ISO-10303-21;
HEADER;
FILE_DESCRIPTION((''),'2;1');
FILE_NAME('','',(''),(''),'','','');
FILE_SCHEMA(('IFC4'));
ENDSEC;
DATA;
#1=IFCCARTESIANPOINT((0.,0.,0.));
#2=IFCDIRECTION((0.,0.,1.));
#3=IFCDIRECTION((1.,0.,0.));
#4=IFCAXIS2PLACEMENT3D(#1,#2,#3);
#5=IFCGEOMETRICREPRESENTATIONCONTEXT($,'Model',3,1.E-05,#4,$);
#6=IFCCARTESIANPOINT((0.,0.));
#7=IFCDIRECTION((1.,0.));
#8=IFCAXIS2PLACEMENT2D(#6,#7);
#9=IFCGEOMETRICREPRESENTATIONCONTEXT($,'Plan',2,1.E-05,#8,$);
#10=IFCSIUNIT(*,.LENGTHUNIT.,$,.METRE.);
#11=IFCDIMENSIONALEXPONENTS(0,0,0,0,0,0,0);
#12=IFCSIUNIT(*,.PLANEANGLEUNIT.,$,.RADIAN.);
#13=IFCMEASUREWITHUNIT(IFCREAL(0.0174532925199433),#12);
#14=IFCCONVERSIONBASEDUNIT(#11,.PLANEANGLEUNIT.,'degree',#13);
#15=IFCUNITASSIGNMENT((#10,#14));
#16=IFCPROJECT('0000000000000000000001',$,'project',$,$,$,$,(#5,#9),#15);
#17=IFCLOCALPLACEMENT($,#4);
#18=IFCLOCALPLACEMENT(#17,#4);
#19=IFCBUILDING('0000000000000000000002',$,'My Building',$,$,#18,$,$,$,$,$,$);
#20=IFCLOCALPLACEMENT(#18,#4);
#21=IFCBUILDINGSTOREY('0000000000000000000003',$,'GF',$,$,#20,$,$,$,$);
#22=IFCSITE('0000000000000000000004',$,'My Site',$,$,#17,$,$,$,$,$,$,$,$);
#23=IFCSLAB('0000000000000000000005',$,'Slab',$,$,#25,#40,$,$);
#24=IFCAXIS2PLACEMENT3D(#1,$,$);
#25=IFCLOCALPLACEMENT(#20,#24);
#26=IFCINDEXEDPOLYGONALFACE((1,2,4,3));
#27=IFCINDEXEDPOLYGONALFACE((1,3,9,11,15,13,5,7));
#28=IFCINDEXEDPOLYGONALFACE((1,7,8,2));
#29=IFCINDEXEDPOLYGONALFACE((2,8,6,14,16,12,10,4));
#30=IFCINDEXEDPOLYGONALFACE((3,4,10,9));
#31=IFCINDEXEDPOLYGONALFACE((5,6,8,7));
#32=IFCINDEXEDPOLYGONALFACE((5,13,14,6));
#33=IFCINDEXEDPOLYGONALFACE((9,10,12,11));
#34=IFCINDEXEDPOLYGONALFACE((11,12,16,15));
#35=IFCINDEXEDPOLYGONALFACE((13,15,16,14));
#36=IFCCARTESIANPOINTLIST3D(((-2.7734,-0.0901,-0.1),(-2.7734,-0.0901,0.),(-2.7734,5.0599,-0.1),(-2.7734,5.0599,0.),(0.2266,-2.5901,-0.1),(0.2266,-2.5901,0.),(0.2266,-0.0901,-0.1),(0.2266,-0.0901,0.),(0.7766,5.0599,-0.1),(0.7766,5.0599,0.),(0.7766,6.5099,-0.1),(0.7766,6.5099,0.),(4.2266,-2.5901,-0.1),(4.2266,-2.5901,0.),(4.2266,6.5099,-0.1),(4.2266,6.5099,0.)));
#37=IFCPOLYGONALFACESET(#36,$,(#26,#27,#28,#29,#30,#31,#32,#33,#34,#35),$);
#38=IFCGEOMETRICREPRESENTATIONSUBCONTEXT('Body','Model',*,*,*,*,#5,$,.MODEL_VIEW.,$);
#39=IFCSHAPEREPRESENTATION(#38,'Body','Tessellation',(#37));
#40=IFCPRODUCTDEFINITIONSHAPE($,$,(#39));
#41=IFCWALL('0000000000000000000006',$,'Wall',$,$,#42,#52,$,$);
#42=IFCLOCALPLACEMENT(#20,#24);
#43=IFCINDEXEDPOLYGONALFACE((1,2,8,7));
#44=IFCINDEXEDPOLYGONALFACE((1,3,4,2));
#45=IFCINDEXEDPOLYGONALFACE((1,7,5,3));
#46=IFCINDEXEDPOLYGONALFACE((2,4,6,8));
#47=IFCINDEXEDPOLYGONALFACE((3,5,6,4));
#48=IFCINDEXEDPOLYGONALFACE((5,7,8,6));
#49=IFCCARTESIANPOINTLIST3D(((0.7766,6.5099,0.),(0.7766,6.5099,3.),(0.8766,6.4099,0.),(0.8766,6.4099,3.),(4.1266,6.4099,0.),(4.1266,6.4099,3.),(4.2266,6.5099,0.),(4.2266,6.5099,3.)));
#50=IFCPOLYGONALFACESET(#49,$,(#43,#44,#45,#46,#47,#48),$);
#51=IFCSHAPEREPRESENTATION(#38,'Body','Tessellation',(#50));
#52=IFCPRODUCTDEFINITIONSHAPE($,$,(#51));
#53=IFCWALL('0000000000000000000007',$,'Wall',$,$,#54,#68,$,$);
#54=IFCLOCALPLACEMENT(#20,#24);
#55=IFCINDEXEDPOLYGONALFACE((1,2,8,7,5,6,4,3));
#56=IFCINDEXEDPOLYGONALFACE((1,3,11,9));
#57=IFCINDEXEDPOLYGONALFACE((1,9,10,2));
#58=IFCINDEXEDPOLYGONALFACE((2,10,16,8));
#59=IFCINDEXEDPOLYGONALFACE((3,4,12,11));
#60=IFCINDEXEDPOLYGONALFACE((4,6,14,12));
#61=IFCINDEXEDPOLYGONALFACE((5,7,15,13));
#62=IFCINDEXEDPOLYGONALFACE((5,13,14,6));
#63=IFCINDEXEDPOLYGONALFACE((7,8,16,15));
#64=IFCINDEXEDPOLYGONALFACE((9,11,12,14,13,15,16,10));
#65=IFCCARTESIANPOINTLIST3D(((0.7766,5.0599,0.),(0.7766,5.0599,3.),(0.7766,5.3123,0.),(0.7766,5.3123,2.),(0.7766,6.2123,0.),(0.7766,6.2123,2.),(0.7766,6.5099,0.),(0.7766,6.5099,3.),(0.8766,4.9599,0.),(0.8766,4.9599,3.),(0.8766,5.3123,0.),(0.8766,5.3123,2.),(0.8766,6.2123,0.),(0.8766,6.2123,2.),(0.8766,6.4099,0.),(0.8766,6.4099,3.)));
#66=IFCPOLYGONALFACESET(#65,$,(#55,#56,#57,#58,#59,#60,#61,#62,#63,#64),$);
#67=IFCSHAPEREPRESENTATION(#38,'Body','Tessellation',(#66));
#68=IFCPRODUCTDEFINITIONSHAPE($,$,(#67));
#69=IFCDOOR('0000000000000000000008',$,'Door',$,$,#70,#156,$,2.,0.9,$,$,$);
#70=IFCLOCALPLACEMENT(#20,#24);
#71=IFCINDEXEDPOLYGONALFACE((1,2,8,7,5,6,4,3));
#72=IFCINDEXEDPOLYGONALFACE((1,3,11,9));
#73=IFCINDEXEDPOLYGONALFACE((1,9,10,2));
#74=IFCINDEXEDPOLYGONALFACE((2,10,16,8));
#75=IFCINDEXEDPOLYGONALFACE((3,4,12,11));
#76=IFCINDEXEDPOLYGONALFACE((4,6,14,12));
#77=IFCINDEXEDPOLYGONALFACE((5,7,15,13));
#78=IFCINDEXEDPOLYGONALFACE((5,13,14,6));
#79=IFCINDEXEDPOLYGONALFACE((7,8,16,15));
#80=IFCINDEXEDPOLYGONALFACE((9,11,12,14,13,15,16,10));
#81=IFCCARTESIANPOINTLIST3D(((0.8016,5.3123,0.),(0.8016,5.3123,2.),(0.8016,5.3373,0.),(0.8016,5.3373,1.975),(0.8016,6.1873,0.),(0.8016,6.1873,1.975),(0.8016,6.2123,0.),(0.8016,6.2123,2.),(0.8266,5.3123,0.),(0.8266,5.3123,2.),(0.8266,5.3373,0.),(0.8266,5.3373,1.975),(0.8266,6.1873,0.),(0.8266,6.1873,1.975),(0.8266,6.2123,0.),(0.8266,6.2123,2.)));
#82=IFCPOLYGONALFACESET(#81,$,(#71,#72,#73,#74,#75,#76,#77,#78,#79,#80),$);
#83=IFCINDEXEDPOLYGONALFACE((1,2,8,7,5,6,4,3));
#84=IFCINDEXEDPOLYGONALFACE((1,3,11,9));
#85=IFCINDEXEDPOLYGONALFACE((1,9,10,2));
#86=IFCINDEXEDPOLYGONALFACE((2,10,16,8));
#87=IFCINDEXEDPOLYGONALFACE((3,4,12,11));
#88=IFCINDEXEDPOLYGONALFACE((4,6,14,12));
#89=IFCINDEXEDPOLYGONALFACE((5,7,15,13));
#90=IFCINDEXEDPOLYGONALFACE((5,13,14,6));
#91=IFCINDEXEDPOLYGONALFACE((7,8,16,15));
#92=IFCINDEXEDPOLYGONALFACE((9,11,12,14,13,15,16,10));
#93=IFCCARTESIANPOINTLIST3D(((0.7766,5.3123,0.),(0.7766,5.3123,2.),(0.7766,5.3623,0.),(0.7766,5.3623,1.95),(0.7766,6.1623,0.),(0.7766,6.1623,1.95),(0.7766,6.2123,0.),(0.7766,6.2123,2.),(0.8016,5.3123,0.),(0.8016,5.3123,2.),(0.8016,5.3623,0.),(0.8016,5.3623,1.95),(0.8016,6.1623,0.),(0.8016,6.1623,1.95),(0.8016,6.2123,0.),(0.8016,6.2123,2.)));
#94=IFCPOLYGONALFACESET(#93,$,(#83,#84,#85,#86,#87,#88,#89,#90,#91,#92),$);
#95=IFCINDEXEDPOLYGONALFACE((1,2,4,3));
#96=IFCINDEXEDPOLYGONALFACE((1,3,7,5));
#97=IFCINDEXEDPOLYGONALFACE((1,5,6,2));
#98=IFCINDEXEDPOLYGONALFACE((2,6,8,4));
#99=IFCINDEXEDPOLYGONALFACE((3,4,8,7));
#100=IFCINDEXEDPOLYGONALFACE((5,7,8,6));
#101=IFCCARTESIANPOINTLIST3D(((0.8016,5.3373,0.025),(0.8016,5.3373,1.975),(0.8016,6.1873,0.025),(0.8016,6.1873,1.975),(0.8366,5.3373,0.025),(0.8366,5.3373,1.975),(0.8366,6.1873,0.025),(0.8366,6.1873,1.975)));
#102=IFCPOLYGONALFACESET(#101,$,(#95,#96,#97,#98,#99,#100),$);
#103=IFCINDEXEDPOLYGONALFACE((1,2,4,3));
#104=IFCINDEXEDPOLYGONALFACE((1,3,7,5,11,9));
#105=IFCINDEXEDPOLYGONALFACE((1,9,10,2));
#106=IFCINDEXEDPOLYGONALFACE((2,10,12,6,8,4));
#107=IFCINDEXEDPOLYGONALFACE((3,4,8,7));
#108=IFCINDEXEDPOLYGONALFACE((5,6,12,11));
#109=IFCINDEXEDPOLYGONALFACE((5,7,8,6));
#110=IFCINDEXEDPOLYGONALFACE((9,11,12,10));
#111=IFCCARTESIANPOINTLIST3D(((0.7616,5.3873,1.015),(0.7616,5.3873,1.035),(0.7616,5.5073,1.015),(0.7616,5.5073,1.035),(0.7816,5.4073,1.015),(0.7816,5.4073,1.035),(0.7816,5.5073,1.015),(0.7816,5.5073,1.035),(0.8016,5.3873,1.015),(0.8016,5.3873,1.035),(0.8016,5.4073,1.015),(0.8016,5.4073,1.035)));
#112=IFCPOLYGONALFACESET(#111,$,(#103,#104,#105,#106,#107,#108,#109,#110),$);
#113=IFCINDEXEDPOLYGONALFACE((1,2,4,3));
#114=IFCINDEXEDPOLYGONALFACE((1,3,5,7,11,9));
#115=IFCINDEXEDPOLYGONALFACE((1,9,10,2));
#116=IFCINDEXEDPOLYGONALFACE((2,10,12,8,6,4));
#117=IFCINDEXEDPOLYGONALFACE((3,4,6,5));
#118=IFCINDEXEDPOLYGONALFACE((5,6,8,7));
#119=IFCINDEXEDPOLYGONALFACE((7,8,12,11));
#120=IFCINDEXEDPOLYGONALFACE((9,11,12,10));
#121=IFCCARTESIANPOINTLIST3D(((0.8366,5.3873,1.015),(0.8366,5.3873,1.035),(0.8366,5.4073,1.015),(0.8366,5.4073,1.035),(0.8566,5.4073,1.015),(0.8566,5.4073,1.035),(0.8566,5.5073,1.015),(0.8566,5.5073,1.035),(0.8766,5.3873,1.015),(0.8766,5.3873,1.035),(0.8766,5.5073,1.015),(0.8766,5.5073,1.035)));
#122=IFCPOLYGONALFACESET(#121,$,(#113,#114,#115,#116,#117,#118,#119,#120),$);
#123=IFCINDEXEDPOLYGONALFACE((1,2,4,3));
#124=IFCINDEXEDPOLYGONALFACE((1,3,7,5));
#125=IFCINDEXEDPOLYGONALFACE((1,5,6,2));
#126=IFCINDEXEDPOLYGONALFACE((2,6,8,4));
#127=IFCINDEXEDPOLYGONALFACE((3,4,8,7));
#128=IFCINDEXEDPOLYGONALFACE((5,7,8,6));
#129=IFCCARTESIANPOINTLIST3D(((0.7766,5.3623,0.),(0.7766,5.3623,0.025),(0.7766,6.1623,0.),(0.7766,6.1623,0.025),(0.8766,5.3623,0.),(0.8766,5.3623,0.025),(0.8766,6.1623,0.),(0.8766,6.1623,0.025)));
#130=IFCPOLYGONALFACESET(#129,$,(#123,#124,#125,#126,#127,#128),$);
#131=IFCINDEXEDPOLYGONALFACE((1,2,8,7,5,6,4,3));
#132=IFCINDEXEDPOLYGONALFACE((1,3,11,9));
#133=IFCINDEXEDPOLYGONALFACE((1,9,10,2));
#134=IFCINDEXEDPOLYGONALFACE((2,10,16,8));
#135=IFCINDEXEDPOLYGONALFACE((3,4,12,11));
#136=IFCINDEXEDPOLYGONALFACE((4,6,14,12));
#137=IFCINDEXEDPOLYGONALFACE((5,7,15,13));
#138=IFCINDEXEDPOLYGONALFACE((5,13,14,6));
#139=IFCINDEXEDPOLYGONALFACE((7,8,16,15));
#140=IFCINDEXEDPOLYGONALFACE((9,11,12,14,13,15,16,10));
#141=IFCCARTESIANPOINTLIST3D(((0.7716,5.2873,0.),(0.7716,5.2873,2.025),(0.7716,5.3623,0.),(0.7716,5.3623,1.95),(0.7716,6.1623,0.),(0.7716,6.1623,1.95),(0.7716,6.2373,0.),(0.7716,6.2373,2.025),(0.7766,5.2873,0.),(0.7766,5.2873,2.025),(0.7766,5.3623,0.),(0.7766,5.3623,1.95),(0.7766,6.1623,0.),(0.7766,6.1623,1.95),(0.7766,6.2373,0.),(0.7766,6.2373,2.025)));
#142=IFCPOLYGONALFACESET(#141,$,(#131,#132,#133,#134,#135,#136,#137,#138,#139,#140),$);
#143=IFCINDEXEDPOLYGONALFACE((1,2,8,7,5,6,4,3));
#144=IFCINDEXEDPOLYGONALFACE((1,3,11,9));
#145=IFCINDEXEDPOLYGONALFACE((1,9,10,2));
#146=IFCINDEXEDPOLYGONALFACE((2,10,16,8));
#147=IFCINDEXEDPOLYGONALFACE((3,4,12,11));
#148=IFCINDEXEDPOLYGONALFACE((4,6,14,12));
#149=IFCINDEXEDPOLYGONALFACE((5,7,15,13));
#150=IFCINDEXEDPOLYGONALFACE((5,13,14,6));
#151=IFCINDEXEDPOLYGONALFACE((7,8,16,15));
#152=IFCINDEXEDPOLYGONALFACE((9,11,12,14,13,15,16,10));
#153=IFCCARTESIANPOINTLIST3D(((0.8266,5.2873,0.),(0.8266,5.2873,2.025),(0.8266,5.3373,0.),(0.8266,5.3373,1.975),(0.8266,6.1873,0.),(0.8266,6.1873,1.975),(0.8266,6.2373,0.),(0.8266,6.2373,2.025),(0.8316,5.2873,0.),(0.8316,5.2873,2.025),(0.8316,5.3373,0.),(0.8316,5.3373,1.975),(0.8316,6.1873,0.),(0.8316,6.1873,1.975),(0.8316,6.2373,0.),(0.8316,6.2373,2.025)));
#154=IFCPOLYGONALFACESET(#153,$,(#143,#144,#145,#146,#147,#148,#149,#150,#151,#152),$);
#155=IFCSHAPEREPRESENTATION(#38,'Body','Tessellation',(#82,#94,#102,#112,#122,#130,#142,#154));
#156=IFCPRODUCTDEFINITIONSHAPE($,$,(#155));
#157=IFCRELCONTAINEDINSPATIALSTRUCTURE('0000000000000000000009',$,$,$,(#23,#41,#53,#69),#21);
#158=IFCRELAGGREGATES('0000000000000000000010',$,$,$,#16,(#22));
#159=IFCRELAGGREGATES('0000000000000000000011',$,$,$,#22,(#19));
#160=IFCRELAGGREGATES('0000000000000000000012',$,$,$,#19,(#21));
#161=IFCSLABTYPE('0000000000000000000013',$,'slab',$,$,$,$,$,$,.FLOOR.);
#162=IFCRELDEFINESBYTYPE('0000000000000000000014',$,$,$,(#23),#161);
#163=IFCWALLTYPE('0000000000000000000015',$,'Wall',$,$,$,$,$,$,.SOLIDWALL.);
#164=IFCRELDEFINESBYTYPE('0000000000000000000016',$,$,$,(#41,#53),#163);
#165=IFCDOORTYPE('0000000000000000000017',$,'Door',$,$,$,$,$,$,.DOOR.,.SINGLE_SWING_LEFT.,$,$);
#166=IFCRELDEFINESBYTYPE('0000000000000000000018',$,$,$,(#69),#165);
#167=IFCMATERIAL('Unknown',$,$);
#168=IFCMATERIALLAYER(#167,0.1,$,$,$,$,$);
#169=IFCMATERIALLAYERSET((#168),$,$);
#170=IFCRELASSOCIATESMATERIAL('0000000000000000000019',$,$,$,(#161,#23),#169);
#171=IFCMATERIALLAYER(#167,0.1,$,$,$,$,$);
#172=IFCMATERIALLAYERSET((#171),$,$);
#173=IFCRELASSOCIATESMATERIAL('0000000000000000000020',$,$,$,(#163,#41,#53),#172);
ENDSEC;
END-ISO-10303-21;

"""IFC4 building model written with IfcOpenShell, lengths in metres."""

from ifc_helpers import new_model, entity, si_unit, converted_unit, frame, origin_with_axes, origin_2d_with_axis, place, context, subcontext, project, spatial, line, indexed_curve, outline, extrude, shape, source, transform, mapped, material, layer, layer_set, layer_usage, type_object, type_shapes, element, fill, save


model = new_model("IFC4")

# Units and contexts
model_context = context("Model", 3, precision=1e-05, world=origin_with_axes())
plan_context = context("Plan", 2, precision=1e-05, world=origin_2d_with_axis())
body_context_1 = subcontext(model_context, "Body", "Model", "MODEL_VIEW")
body_context_2 = subcontext(plan_context, "Body", "Plan", "PLAN_VIEW")
ifc_project = project(units=[si_unit("LENGTHUNIT", "METRE"), converted_unit("PLANEANGLEUNIT", "degree", entity("IfcReal", 0.0174532925199433), si_unit("PLANEANGLEUNIT", "RADIAN"), dimensions=[0, 0, 0, 0, 0, 0, 0])], contexts=[model_context, plan_context])

# Site, building, storey
site_placement = place(None, origin_with_axes())
site = spatial("IfcSite", under=ifc_project, at=site_placement, Name="My Site")
building_placement = place(site_placement, origin_with_axes())
building = spatial("IfcBuilding", under=site, at=building_placement, Name="My Building")
storey_placement = place(building_placement, origin_with_axes())
storey = spatial("IfcBuildingStorey", under=building, at=storey_placement, Name="GF")

# Slab
ifc_material = material(Name="Unknown")
ifc_layer_1 = layer(ifc_material, 0.1)
ifc_layer_set_1 = layer_set([ifc_layer_1])
ifc_layer_usage_1 = layer_usage(ifc_layer_set_1, "AXIS3", "POSITIVE", -0.1)
slab_type = type_object("IfcSlabType", Name="slab", PredefinedType="FLOOR", material=ifc_layer_set_1)
slab_placement = place(storey_placement, frame((4.2266, -2.5901, 0.0), z_axis=(0.0, 0.0, 1.0), x_axis=(1.0, 0.0, 0.0)))
element("IfcSlab", 1, at=slab_placement, inside=storey, type_object=slab_type, material=ifc_layer_usage_1, Name="Slab", context=body_context_1, shape_type="SweptSolid", body=[
    extrude(outline(indexed_curve([(0.0, 0.0), (0.0, 9.1), (-3.45, 9.1), (-3.45, 7.65), (-7.0, 7.65), (-7.0, 2.5), (-4.0, 2.5), (-4.0, 0.0), (0.0, 0.0)])), frame((0.0, 0.0, -0.1), z_axis=(0.0, 0.0, 1.0), x_axis=(1.0, 0.0, 0.0)), (0.0, 0.0, 1.0), 0.1),
])

# Wall
ifc_layer_2 = layer(ifc_material, 0.1)
ifc_layer_set_2 = layer_set([ifc_layer_2])
ifc_layer_usage_2 = layer_usage(ifc_layer_set_2, "AXIS2", "POSITIVE", 0.0)
wall_type = type_object("IfcWallType", Name="Wall", PredefinedType="SOLIDWALL", material=ifc_layer_set_2)
wall_1_placement = place(storey_placement, frame((4.2266, 6.5099, 0.0), z_axis=(0.0, 0.0, 1.0), x_axis=(-1.0, 0.0, 0.0)))
element("IfcWall", 2, at=wall_1_placement, inside=storey, type_object=wall_type, material=ifc_layer_usage_2, Name="Wall", context=body_context_1, shape_type="SweptSolid", body=[
    extrude(outline(indexed_curve([(0.0, 0.0), (0.1, 0.1), (3.35, 0.1), (3.45, 0.0)], segments=[line(1, 2, 3, 4, 1)])), origin_with_axes(), (0.0, 0.0, 1.0), 3.0),
])

# Wall, opening, door
ifc_layer_usage_3 = layer_usage(ifc_layer_set_2, "AXIS2", "POSITIVE", 0.0)
wall_2_placement = place(storey_placement, frame((0.7766, 6.5099, 0.0), z_axis=(0.0, 0.0, 1.0), x_axis=(0.0, -1.0, 0.0)))
wall_2 = element("IfcWall", 3, at=wall_2_placement, inside=storey, type_object=wall_type, material=ifc_layer_usage_3, Name="Wall", context=body_context_1, shape_type="SweptSolid", body=[
    extrude(outline(indexed_curve([(0.0, 0.0), (0.1, 0.1), (1.55, 0.1), (1.45, 0.0)], segments=[line(1, 2, 3, 4, 1)])), origin_with_axes(), (0.0, 0.0, 1.0), 3.0),
])
shared_shape_1 = source(origin_with_axes(), body_context_1, "Body", "SweptSolid", [
    extrude(outline(indexed_curve([(0.0, 0.0), (0.9, 0.0), (0.9, 2.0), (0.0, 2.0)], segments=[line(1, 2, 3, 4, 1)])), frame((0.0, -0.6, 0.0), z_axis=(0.0, -1.0, 0.0), x_axis=(1.0, 0.0, 0.0)), (0.0, 0.0, -1.0), 1.2),
])
opening_1_placement = place(wall_2_placement, frame((0.2976, 0.0, 0.0), z_axis=(0.0, 0.0, 1.0), x_axis=(1.0, 0.0, 0.0)))
opening_1 = element("IfcOpeningElement", 4, at=opening_1_placement, cuts=wall_2, PredefinedType="OPENING", context=body_context_1, shape_type="MappedRepresentation", body=[
    mapped(shared_shape_1, transform((0.0, 0.0, 0.0), x_axis=(1.0, 0.0, 0.0), y_axis=(0.0, 1.0, 0.0), z_axis=(0.0, 0.0, 1.0), scale=1.0)),
])
door_type = type_object("IfcDoorType", Name="Door", OperationType="SINGLE_SWING_LEFT", PredefinedType="DOOR")
shared_shape_2 = source(origin_with_axes(), body_context_1, "Body", "SweptSolid", [
    extrude(outline(indexed_curve([(0.0, 0.0), (0.0, 2.0), (0.9, 2.0), (0.9, 0.0), (0.875, 0.0), (0.875, 1.975), (0.025, 1.975), (0.025, 0.0)], segments=[line(1, 2, 3, 4, 5, 6, 7, 8, 1)])), frame((0.0, 0.025, 0.0), z_axis=(0.0, -1.0, 0.0), x_axis=(1.0, 0.0, 0.0)), (0.0, 0.0, -1.0), 0.025),
    extrude(outline(indexed_curve([(0.0, 0.0), (0.0, 2.0), (0.9, 2.0), (0.9, 0.0), (0.85, 0.0), (0.85, 1.95), (0.05, 1.95), (0.05, 0.0)], segments=[line(1, 2, 3, 4, 5, 6, 7, 8, 1)])), frame((0.0, 0.0, 0.0), z_axis=(0.0, -1.0, 0.0), x_axis=(1.0, 0.0, 0.0)), (0.0, 0.0, -1.0), 0.025),
    extrude(outline(indexed_curve([(0.0, 0.0), (0.85, 0.0), (0.85, 0.035), (0.0, 0.035)], segments=[line(1, 2, 3, 4, 1)])), frame((0.025, 0.025, 0.025), z_axis=(0.0, 0.0, 1.0), x_axis=(1.0, 0.0, 0.0)), (0.0, 0.0, 1.0), 1.95),
    extrude(outline(indexed_curve([(0.0, 0.0), (0.0, -0.04), (-0.12, -0.04), (-0.12, -0.02), (-0.02, -0.02), (-0.02, 0.0)], segments=[line(1, 2, 3, 4, 5, 6, 1)])), frame((0.825, 0.025, 1.015), z_axis=(0.0, 0.0, 1.0), x_axis=(1.0, 0.0, 0.0)), (0.0, 0.0, 1.0), 0.02),
    extrude(outline(indexed_curve([(0.0, 0.0), (0.0, 0.04), (-0.12, 0.04), (-0.12, 0.02), (-0.02, 0.02), (-0.02, 0.0)], segments=[line(1, 2, 3, 4, 5, 6, 1)])), frame((0.825, 0.06, 1.015), z_axis=(0.0, 0.0, 1.0), x_axis=(1.0, 0.0, 0.0)), (0.0, 0.0, 1.0), 0.02),
    extrude(outline(indexed_curve([(0.0, 0.0), (0.8, 0.0), (0.8, 0.1), (0.0, 0.1)], segments=[line(1, 2, 3, 4, 1)])), frame((0.05, 0.0, 0.0), z_axis=(0.0, 0.0, 1.0), x_axis=(1.0, 0.0, 0.0)), (0.0, 0.0, 1.0), 0.025),
    extrude(outline(indexed_curve([(0.0, 0.0), (0.0, 2.025), (0.95, 2.025), (0.95, 0.0), (0.875, 0.0), (0.875, 1.95), (0.075, 1.95), (0.075, 0.0)], segments=[line(1, 2, 3, 4, 5, 6, 7, 8, 1)])), frame((-0.025, -0.005, 0.0), z_axis=(0.0, -1.0, 0.0), x_axis=(1.0, 0.0, 0.0)), (0.0, 0.0, -1.0), 0.005),
    extrude(outline(indexed_curve([(0.0, 0.0), (0.0, 2.025), (0.95, 2.025), (0.95, 0.0), (0.9, 0.0), (0.9, 1.975), (0.05, 1.975), (0.05, 0.0)], segments=[line(1, 2, 3, 4, 5, 6, 7, 8, 1)])), frame((-0.025, 0.05, 0.0), z_axis=(0.0, -1.0, 0.0), x_axis=(1.0, 0.0, 0.0)), (0.0, 0.0, -1.0), 0.005),
])
shared_shape_3 = source(origin_with_axes(), body_context_2, "Body", "Curve2D", [
    entity("IfcIndexedPolyCurve", entity("IfcCartesianPointList2D", [[0.0, 0.0], [0.0, 0.05], [0.025, 0.05], [0.025, 0.025], [0.05, 0.025], [0.05, 0.0]]), [entity("IfcLineIndex", [1, 2, 3, 4, 5, 6, 1])]),
    entity("IfcIndexedPolyCurve", entity("IfcCartesianPointList2D", [[0.9, 0.0], [0.9, 0.05], [0.875, 0.05], [0.875, 0.025], [0.85, 0.025], [0.85, 0.0]]), [entity("IfcLineIndex", [1, 2, 3, 4, 5, 6, 1])]),
    entity("IfcTrimmedCurve", entity("IfcEllipse", entity("IfcAxis2Placement2D", entity("IfcCartesianPoint", [0.06, 0.05]), entity("IfcDirection", [1.0, 0.0])), 0.815, 0.85), [entity("IfcCartesianPoint", [0.875, 0.05])], [entity("IfcCartesianPoint", [0.06, 0.9])], True, "CARTESIAN"),
    entity("IfcIndexedPolyCurve", entity("IfcCartesianPointList2D", [[0.025, 0.05], [0.06, 0.05], [0.06, 0.9], [0.025, 0.9]]), [entity("IfcLineIndex", [1, 2, 3, 4, 1])]),
])
type_shapes(door_type, [shared_shape_2, shared_shape_3])
door_1_placement = place(opening_1_placement, frame((0.0, 0.0, 0.0), z_axis=(0.0, 0.0, 1.0), x_axis=(1.0, 0.0, 0.0)))
door_1 = element("IfcDoor", 5, at=door_1_placement, inside=storey, type_object=door_type, Name="Door", OverallHeight=2.0, OverallWidth=0.9, shapes=[
    shape(body_context_1, "Body", "MappedRepresentation", [mapped(shared_shape_2, transform((0.0, 0.0, 0.0), x_axis=(1.0, 0.0, 0.0), y_axis=(0.0, 1.0, 0.0), z_axis=(0.0, 0.0, 1.0), scale=1.0))]),
    shape(body_context_2, "Body", "MappedRepresentation", [mapped(shared_shape_3, transform((0.0, 0.0, 0.0), x_axis=(1.0, 0.0, 0.0), y_axis=(0.0, 1.0, 0.0), z_axis=(0.0, 0.0, 1.0), scale=1.0))]),
])
fill(opening_1, door_1)

save(model, "model.ifc")
